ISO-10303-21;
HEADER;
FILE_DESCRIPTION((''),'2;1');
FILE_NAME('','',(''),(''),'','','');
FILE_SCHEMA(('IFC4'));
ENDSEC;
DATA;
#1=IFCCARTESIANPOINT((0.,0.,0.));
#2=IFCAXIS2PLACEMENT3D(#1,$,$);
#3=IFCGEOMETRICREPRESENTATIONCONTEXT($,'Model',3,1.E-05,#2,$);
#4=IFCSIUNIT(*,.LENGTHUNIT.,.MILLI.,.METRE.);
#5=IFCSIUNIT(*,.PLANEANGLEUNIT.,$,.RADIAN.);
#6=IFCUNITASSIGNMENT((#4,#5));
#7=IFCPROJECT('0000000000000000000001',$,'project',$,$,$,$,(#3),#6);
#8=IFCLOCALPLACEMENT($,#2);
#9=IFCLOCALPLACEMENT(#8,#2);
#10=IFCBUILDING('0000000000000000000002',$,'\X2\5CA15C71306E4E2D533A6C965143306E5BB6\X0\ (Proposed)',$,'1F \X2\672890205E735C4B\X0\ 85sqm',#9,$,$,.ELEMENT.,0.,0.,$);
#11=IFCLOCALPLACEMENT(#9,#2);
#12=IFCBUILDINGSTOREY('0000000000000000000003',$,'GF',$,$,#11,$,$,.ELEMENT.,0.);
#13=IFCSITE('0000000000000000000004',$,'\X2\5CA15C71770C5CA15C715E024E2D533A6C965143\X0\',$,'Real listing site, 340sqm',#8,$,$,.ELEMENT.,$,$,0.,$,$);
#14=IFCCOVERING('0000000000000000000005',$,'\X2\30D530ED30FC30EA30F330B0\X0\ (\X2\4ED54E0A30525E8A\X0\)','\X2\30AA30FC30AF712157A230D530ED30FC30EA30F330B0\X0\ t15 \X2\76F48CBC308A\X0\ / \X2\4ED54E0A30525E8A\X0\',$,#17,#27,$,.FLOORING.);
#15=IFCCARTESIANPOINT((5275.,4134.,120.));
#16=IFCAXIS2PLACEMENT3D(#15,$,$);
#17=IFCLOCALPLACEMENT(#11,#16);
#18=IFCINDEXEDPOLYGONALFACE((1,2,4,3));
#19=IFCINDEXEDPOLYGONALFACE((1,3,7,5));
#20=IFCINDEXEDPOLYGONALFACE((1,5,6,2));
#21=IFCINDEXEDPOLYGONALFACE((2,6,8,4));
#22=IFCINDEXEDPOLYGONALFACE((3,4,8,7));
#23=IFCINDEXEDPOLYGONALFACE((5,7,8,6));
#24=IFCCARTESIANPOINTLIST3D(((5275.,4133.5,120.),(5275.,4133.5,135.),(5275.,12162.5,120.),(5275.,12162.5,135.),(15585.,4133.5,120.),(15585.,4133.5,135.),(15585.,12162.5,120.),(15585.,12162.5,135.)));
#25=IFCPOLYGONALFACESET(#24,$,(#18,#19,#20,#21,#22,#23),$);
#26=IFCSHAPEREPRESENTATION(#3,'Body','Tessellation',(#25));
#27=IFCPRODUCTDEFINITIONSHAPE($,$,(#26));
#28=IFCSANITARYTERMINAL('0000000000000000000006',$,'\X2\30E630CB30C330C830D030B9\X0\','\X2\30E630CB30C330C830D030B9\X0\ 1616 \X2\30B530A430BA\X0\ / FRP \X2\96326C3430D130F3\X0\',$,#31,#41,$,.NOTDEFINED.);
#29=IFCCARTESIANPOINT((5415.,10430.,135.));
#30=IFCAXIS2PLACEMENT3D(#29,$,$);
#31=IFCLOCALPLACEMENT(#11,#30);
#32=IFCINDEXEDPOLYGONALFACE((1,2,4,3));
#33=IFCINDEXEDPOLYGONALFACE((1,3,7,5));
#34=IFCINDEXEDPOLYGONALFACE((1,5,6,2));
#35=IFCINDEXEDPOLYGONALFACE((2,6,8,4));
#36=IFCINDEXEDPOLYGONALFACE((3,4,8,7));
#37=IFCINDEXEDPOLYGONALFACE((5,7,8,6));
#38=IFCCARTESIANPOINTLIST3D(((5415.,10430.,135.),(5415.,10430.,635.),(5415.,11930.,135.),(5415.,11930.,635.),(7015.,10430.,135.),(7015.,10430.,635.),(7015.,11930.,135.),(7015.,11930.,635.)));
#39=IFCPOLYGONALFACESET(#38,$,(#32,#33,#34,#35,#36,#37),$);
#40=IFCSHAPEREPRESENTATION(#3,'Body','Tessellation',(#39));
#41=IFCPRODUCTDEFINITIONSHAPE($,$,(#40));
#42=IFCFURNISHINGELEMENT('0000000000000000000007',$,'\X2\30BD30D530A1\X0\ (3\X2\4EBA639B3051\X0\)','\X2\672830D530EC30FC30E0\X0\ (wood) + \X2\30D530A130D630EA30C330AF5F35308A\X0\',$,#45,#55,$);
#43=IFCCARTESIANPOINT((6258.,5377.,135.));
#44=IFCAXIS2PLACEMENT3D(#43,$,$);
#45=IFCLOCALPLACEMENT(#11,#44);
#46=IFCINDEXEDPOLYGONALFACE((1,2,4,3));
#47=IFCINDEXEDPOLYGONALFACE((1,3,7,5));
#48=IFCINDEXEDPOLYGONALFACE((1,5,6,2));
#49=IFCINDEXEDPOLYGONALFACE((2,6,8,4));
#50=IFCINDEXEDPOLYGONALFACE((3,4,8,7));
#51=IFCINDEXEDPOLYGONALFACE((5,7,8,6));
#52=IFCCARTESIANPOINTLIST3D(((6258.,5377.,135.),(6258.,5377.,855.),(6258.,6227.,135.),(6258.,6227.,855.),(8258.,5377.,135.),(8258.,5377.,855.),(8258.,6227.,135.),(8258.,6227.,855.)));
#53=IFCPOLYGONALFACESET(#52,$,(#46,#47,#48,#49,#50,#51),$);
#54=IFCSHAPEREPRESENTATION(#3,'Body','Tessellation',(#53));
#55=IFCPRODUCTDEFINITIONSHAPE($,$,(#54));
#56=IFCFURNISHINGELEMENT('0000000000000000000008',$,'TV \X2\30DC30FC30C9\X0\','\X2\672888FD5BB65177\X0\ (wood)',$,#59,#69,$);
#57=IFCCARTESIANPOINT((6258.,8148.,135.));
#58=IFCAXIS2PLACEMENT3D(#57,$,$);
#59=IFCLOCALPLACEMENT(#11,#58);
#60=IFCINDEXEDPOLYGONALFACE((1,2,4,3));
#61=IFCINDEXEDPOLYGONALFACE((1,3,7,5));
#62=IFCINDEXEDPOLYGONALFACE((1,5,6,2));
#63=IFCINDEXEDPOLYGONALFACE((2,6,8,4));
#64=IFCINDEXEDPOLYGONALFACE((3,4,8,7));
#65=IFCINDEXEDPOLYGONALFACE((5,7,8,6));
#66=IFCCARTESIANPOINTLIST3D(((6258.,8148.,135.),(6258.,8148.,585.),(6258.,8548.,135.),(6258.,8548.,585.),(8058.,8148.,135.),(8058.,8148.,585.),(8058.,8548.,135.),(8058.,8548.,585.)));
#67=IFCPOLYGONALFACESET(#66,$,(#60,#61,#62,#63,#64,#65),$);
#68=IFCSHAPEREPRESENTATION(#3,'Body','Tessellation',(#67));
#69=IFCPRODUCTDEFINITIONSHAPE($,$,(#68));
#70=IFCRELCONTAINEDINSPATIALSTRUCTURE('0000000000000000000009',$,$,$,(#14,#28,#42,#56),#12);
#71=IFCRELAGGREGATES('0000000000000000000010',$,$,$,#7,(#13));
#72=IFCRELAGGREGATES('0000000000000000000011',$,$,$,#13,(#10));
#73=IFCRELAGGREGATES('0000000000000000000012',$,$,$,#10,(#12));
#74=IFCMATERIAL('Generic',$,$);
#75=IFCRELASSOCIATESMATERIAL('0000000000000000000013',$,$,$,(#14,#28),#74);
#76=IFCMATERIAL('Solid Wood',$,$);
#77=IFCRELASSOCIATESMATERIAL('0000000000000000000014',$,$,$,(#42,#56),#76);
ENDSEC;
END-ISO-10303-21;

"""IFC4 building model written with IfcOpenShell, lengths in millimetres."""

from ifc_helpers import new_model, si_unit, frame, frame_2d, origin, place, context, project, spatial, rectangle, extrude, material, element, save


model = new_model("IFC4")

# Units and contexts
model_context = context("Model", 3, precision=1e-05, world=origin())
ifc_project = project(units=[si_unit("LENGTHUNIT", "METRE", prefix="MILLI"), si_unit("PLANEANGLEUNIT", "RADIAN")], contexts=[model_context])

# Site, building, storey
site_placement = place(None, origin())
site = spatial("IfcSite", under=ifc_project, at=site_placement, Name="岡山県岡山市中区沖元", ObjectType="Real listing site, 340sqm", CompositionType="ELEMENT", RefElevation=0.0)
building_placement = place(site_placement, origin())
building = spatial("IfcBuilding", under=site, at=building_placement, Name="岡山の中区沖元の家 (Proposed)", ObjectType="1F 木造平屋 85sqm", CompositionType="ELEMENT", ElevationOfRefHeight=0.0, ElevationOfTerrain=0.0)
storey_placement = place(building_placement, origin())
storey = spatial("IfcBuildingStorey", under=building, at=storey_placement, Name="GF", CompositionType="ELEMENT", Elevation=0.0)

# Shared definitions
ifc_material_1 = material(Name="Solid Wood")

# Covering
ifc_material_2 = material(Name="Generic")
covering_placement = place(storey_placement, frame((5275.0, 4134.0, 120.0)))
element("IfcCovering", 1, at=covering_placement, inside=storey, material=ifc_material_2, Name="フローリング (仕上げ床)", Description="オーク無垢フローリング t15 直貼り / 仕上げ床", PredefinedType="FLOORING", context=model_context, shape_type="SweptSolid", body=[
    extrude(rectangle(XDim=10310.0, YDim=8029.0, at=frame_2d((5155.0, 4014.0))), frame((5275.0, 4134.0, 120.0)), (0.0, 0.0, 1.0), 15.0),
])

# Sanitary terminal
sanitary_terminal_placement = place(storey_placement, frame((5415.0, 10430.0, 135.0)))
element("IfcSanitaryTerminal", 2, at=sanitary_terminal_placement, inside=storey, material=ifc_material_2, Name="ユニットバス", Description="ユニットバス 1616 サイズ / FRP 防水パン", PredefinedType="NOTDEFINED", context=model_context, shape_type="SweptSolid", body=[
    extrude(rectangle(XDim=1600.0, YDim=1500.0, at=frame_2d((800.0, 750.0))), frame((5415.0, 10430.0, 135.0)), (0.0, 0.0, 1.0), 500.0),
])

# Furnishing elements
furnishing_1_placement = place(storey_placement, frame((6258.0, 5377.0, 135.0)))
element("IfcFurnishingElement", 3, at=furnishing_1_placement, inside=storey, material=ifc_material_1, Name="ソファ (3人掛け)", Description="木フレーム (wood) + ファブリック張り", context=model_context, shape_type="SweptSolid", body=[
    extrude(rectangle(XDim=2000.0, YDim=850.0, at=frame_2d((1000.0, 425.0))), frame((6258.0, 5377.0, 135.0)), (0.0, 0.0, 1.0), 720.0),
])
furnishing_2_placement = place(storey_placement, frame((6258.0, 8148.0, 135.0)))
element("IfcFurnishingElement", 4, at=furnishing_2_placement, inside=storey, material=ifc_material_1, Name="TV ボード", Description="木製家具 (wood)", context=model_context, shape_type="SweptSolid", body=[
    extrude(rectangle(XDim=1800.0, YDim=400.0, at=frame_2d((900.0, 200.0))), frame((6258.0, 8148.0, 135.0)), (0.0, 0.0, 1.0), 450.0),
])

save(model, "model.ifc")
